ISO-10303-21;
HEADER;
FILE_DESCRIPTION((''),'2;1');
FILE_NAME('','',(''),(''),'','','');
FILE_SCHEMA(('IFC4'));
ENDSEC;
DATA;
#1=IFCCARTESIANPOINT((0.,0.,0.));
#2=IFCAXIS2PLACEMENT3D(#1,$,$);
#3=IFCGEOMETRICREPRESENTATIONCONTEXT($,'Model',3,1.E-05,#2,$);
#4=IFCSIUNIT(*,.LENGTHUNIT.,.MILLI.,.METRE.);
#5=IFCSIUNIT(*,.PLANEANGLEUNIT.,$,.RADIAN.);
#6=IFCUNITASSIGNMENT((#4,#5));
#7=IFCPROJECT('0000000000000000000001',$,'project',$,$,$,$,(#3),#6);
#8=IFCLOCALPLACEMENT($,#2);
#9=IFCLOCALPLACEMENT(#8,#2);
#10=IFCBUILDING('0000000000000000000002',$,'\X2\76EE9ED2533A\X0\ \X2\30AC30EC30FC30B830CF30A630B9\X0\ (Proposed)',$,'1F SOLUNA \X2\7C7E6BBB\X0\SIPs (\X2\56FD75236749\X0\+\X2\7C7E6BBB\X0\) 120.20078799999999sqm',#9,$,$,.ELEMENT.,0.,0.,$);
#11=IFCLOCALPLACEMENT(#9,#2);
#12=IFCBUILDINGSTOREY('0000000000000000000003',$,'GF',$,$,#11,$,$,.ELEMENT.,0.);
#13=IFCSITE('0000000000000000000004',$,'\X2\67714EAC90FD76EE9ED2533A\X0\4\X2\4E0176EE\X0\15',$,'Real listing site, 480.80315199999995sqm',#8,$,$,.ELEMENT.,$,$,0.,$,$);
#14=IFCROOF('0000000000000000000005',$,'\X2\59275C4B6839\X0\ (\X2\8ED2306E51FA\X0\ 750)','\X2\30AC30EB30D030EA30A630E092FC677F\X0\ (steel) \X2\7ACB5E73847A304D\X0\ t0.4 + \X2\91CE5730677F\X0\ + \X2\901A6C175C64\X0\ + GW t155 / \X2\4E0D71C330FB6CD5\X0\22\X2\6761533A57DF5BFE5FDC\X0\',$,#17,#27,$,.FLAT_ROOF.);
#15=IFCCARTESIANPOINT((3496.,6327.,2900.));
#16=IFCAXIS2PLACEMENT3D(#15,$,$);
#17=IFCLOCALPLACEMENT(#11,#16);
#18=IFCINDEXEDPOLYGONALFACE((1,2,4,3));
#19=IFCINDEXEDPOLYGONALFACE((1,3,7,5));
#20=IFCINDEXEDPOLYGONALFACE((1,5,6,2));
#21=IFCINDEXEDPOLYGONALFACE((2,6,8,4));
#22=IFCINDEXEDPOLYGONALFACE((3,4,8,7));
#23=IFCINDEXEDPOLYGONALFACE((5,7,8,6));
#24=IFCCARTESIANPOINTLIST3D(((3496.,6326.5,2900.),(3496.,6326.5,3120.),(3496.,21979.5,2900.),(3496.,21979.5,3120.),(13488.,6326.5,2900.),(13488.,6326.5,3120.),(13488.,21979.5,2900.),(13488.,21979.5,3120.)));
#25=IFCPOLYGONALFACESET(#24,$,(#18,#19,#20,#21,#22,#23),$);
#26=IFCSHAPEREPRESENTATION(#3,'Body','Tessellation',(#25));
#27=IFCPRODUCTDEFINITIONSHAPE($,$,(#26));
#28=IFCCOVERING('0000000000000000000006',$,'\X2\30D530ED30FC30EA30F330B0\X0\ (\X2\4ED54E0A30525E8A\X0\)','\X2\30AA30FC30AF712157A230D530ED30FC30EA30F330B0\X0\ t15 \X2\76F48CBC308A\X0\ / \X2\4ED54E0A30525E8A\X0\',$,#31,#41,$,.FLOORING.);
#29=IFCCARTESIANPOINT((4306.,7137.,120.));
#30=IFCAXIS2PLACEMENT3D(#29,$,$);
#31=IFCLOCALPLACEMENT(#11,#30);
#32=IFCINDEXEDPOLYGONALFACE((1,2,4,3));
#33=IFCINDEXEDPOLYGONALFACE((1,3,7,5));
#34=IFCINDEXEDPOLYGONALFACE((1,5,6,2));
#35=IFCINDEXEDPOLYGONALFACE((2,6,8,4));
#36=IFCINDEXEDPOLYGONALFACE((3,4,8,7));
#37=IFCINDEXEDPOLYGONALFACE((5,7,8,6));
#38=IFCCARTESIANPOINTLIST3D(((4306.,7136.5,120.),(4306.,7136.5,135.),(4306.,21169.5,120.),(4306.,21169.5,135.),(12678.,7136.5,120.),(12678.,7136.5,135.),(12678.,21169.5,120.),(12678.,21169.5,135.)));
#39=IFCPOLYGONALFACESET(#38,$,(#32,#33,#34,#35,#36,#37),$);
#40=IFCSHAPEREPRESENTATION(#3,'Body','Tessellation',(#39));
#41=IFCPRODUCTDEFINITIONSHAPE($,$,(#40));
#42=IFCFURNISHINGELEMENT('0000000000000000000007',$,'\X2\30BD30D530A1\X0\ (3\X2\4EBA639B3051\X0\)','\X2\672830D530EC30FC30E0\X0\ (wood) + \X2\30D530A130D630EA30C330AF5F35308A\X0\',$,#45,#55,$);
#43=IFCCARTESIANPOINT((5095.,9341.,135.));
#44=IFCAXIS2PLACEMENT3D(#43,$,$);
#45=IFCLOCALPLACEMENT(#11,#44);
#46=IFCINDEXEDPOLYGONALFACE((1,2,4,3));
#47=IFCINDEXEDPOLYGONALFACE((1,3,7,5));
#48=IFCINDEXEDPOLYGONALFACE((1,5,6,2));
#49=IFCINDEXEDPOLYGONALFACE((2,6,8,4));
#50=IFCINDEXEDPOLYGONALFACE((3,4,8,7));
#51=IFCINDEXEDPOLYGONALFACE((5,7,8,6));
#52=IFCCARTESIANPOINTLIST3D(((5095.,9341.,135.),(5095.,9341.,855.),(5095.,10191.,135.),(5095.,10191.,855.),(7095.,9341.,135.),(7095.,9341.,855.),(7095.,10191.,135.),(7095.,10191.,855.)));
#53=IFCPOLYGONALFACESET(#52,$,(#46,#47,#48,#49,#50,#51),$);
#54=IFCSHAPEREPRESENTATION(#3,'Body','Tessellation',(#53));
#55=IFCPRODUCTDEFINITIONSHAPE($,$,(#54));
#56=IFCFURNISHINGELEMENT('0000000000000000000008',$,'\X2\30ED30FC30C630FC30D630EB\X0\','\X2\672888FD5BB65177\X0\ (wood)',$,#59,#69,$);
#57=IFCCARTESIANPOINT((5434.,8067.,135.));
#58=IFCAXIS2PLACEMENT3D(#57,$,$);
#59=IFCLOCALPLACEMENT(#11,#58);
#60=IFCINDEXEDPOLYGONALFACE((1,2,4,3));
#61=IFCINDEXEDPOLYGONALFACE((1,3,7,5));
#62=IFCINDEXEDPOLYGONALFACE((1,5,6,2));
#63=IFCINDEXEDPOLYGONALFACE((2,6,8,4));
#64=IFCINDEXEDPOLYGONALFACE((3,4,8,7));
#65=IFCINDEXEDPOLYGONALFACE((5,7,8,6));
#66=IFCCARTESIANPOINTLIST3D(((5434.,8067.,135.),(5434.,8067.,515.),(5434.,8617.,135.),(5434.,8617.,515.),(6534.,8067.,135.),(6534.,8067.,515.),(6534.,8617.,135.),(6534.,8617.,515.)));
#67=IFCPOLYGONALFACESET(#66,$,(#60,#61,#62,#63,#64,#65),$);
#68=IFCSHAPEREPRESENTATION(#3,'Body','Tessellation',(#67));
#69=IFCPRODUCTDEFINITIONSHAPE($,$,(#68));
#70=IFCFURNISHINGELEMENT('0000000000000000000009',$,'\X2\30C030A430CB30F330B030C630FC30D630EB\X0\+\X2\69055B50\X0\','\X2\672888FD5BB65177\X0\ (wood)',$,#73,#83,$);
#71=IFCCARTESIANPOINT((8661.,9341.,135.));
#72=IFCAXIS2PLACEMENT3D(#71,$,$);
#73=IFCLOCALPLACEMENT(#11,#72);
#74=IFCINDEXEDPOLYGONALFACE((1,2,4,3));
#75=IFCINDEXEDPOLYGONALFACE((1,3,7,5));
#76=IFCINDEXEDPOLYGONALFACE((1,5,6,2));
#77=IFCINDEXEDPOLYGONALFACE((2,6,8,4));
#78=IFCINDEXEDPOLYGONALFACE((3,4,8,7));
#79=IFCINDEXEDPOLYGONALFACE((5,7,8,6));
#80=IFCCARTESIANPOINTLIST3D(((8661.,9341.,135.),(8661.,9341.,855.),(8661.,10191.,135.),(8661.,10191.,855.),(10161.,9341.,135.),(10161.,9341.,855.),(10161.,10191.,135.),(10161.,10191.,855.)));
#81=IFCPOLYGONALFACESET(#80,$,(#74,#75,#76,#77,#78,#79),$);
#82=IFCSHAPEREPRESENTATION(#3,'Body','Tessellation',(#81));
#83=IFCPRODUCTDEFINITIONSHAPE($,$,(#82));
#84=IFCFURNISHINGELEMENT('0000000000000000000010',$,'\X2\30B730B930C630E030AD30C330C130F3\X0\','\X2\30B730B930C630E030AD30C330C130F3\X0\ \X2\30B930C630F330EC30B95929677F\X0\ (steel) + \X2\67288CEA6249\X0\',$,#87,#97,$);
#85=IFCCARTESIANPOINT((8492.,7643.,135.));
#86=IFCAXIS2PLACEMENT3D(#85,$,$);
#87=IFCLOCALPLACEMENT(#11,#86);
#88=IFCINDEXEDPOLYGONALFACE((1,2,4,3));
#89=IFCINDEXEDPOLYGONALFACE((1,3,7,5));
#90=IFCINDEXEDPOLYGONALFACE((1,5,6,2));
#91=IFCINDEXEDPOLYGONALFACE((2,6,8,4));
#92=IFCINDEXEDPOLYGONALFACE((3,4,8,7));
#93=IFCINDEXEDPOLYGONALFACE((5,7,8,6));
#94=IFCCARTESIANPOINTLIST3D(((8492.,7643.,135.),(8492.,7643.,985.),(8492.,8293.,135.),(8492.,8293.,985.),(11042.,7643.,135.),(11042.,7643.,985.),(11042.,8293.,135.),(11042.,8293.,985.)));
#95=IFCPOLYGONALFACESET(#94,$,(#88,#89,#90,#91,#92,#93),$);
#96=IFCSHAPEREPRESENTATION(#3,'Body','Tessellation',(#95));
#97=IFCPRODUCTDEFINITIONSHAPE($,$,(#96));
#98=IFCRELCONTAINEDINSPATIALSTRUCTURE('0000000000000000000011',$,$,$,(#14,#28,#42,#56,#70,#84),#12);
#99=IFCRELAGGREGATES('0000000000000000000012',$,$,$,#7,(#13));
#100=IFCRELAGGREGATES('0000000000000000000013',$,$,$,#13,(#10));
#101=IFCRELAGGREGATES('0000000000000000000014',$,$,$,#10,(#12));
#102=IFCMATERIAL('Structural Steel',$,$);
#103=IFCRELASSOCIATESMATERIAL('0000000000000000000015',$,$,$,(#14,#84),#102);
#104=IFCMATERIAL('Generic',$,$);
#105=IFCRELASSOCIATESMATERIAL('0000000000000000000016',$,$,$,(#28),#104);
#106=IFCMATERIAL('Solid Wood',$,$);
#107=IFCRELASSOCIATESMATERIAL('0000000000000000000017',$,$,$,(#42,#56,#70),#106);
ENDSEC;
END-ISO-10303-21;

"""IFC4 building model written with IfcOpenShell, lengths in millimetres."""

from ifc_helpers import new_model, si_unit, frame, frame_2d, origin, place, context, project, spatial, rectangle, extrude, material, element, save


model = new_model("IFC4")

# Units and contexts
model_context = context("Model", 3, precision=1e-05, world=origin())
ifc_project = project(units=[si_unit("LENGTHUNIT", "METRE", prefix="MILLI"), si_unit("PLANEANGLEUNIT", "RADIAN")], contexts=[model_context])

# Site, building, storey
site_placement = place(None, origin())
site = spatial("IfcSite", under=ifc_project, at=site_placement, Name="東京都目黒区4丁目15", ObjectType="Real listing site, 480.80315199999995sqm", CompositionType="ELEMENT", RefElevation=0.0)
building_placement = place(site_placement, origin())
building = spatial("IfcBuilding", under=site, at=building_placement, Name="目黒区 ガレージハウス (Proposed)", ObjectType="1F SOLUNA 籾殻SIPs (国産杉+籾殻) 120.20078799999999sqm", CompositionType="ELEMENT", ElevationOfRefHeight=0.0, ElevationOfTerrain=0.0)
storey_placement = place(building_placement, origin())
storey = spatial("IfcBuildingStorey", under=building, at=storey_placement, Name="GF", CompositionType="ELEMENT", Elevation=0.0)

# Shared definitions
ifc_material_1 = material(Name="Solid Wood")

# Roof
ifc_material_2 = material(Name="Structural Steel")
roof_placement = place(storey_placement, frame((3496.0, 6327.0, 2900.0)))
element("IfcRoof", 1, at=roof_placement, inside=storey, material=ifc_material_2, Name="大屋根 (軒の出 750)", Description="ガルバリウム鋼板 (steel) 立平葺き t0.4 + 野地板 + 通気層 + GW t155 / 不燃・法22条区域対応", PredefinedType="FLAT_ROOF", context=model_context, shape_type="SweptSolid", body=[
    extrude(rectangle(XDim=9992.0, YDim=15653.0, at=frame_2d((4996.0, 7826.0))), frame((3496.0, 6327.0, 2900.0)), (0.0, 0.0, 1.0), 220.0),
])

# Covering
ifc_material_3 = material(Name="Generic")
covering_placement = place(storey_placement, frame((4306.0, 7137.0, 120.0)))
element("IfcCovering", 2, at=covering_placement, inside=storey, material=ifc_material_3, Name="フローリング (仕上げ床)", Description="オーク無垢フローリング t15 直貼り / 仕上げ床", PredefinedType="FLOORING", context=model_context, shape_type="SweptSolid", body=[
    extrude(rectangle(XDim=8372.0, YDim=14033.0, at=frame_2d((4186.0, 7016.0))), frame((4306.0, 7137.0, 120.0)), (0.0, 0.0, 1.0), 15.0),
])

# Furnishing elements
furnishing_1_placement = place(storey_placement, frame((5095.0, 9341.0, 135.0)))
element("IfcFurnishingElement", 3, at=furnishing_1_placement, inside=storey, material=ifc_material_1, Name="ソファ (3人掛け)", Description="木フレーム (wood) + ファブリック張り", context=model_context, shape_type="SweptSolid", body=[
    extrude(rectangle(XDim=2000.0, YDim=850.0, at=frame_2d((1000.0, 425.0))), frame((5095.0, 9341.0, 135.0)), (0.0, 0.0, 1.0), 720.0),
])
furnishing_2_placement = place(storey_placement, frame((5434.0, 8067.0, 135.0)))
element("IfcFurnishingElement", 4, at=furnishing_2_placement, inside=storey, material=ifc_material_1, Name="ローテーブル", Description="木製家具 (wood)", context=model_context, shape_type="SweptSolid", body=[
    extrude(rectangle(XDim=1100.0, YDim=550.0, at=frame_2d((550.0, 275.0))), frame((5434.0, 8067.0, 135.0)), (0.0, 0.0, 1.0), 380.0),
])
furnishing_3_placement = place(storey_placement, frame((8661.0, 9341.0, 135.0)))
element("IfcFurnishingElement", 5, at=furnishing_3_placement, inside=storey, material=ifc_material_1, Name="ダイニングテーブル+椅子", Description="木製家具 (wood)", context=model_context, shape_type="SweptSolid", body=[
    extrude(rectangle(XDim=1500.0, YDim=850.0, at=frame_2d((750.0, 425.0))), frame((8661.0, 9341.0, 135.0)), (0.0, 0.0, 1.0), 720.0),
])
furnishing_4_placement = place(storey_placement, frame((8492.0, 7643.0, 135.0)))
element("IfcFurnishingElement", 6, at=furnishing_4_placement, inside=storey, material=ifc_material_2, Name="システムキッチン", Description="システムキッチン ステンレス天板 (steel) + 木質扉", context=model_context, shape_type="SweptSolid", body=[
    extrude(rectangle(XDim=2550.0, YDim=650.0, at=frame_2d((1275.0, 325.0))), frame((8492.0, 7643.0, 135.0)), (0.0, 0.0, 1.0), 850.0),
])

save(model, "model.ifc")
